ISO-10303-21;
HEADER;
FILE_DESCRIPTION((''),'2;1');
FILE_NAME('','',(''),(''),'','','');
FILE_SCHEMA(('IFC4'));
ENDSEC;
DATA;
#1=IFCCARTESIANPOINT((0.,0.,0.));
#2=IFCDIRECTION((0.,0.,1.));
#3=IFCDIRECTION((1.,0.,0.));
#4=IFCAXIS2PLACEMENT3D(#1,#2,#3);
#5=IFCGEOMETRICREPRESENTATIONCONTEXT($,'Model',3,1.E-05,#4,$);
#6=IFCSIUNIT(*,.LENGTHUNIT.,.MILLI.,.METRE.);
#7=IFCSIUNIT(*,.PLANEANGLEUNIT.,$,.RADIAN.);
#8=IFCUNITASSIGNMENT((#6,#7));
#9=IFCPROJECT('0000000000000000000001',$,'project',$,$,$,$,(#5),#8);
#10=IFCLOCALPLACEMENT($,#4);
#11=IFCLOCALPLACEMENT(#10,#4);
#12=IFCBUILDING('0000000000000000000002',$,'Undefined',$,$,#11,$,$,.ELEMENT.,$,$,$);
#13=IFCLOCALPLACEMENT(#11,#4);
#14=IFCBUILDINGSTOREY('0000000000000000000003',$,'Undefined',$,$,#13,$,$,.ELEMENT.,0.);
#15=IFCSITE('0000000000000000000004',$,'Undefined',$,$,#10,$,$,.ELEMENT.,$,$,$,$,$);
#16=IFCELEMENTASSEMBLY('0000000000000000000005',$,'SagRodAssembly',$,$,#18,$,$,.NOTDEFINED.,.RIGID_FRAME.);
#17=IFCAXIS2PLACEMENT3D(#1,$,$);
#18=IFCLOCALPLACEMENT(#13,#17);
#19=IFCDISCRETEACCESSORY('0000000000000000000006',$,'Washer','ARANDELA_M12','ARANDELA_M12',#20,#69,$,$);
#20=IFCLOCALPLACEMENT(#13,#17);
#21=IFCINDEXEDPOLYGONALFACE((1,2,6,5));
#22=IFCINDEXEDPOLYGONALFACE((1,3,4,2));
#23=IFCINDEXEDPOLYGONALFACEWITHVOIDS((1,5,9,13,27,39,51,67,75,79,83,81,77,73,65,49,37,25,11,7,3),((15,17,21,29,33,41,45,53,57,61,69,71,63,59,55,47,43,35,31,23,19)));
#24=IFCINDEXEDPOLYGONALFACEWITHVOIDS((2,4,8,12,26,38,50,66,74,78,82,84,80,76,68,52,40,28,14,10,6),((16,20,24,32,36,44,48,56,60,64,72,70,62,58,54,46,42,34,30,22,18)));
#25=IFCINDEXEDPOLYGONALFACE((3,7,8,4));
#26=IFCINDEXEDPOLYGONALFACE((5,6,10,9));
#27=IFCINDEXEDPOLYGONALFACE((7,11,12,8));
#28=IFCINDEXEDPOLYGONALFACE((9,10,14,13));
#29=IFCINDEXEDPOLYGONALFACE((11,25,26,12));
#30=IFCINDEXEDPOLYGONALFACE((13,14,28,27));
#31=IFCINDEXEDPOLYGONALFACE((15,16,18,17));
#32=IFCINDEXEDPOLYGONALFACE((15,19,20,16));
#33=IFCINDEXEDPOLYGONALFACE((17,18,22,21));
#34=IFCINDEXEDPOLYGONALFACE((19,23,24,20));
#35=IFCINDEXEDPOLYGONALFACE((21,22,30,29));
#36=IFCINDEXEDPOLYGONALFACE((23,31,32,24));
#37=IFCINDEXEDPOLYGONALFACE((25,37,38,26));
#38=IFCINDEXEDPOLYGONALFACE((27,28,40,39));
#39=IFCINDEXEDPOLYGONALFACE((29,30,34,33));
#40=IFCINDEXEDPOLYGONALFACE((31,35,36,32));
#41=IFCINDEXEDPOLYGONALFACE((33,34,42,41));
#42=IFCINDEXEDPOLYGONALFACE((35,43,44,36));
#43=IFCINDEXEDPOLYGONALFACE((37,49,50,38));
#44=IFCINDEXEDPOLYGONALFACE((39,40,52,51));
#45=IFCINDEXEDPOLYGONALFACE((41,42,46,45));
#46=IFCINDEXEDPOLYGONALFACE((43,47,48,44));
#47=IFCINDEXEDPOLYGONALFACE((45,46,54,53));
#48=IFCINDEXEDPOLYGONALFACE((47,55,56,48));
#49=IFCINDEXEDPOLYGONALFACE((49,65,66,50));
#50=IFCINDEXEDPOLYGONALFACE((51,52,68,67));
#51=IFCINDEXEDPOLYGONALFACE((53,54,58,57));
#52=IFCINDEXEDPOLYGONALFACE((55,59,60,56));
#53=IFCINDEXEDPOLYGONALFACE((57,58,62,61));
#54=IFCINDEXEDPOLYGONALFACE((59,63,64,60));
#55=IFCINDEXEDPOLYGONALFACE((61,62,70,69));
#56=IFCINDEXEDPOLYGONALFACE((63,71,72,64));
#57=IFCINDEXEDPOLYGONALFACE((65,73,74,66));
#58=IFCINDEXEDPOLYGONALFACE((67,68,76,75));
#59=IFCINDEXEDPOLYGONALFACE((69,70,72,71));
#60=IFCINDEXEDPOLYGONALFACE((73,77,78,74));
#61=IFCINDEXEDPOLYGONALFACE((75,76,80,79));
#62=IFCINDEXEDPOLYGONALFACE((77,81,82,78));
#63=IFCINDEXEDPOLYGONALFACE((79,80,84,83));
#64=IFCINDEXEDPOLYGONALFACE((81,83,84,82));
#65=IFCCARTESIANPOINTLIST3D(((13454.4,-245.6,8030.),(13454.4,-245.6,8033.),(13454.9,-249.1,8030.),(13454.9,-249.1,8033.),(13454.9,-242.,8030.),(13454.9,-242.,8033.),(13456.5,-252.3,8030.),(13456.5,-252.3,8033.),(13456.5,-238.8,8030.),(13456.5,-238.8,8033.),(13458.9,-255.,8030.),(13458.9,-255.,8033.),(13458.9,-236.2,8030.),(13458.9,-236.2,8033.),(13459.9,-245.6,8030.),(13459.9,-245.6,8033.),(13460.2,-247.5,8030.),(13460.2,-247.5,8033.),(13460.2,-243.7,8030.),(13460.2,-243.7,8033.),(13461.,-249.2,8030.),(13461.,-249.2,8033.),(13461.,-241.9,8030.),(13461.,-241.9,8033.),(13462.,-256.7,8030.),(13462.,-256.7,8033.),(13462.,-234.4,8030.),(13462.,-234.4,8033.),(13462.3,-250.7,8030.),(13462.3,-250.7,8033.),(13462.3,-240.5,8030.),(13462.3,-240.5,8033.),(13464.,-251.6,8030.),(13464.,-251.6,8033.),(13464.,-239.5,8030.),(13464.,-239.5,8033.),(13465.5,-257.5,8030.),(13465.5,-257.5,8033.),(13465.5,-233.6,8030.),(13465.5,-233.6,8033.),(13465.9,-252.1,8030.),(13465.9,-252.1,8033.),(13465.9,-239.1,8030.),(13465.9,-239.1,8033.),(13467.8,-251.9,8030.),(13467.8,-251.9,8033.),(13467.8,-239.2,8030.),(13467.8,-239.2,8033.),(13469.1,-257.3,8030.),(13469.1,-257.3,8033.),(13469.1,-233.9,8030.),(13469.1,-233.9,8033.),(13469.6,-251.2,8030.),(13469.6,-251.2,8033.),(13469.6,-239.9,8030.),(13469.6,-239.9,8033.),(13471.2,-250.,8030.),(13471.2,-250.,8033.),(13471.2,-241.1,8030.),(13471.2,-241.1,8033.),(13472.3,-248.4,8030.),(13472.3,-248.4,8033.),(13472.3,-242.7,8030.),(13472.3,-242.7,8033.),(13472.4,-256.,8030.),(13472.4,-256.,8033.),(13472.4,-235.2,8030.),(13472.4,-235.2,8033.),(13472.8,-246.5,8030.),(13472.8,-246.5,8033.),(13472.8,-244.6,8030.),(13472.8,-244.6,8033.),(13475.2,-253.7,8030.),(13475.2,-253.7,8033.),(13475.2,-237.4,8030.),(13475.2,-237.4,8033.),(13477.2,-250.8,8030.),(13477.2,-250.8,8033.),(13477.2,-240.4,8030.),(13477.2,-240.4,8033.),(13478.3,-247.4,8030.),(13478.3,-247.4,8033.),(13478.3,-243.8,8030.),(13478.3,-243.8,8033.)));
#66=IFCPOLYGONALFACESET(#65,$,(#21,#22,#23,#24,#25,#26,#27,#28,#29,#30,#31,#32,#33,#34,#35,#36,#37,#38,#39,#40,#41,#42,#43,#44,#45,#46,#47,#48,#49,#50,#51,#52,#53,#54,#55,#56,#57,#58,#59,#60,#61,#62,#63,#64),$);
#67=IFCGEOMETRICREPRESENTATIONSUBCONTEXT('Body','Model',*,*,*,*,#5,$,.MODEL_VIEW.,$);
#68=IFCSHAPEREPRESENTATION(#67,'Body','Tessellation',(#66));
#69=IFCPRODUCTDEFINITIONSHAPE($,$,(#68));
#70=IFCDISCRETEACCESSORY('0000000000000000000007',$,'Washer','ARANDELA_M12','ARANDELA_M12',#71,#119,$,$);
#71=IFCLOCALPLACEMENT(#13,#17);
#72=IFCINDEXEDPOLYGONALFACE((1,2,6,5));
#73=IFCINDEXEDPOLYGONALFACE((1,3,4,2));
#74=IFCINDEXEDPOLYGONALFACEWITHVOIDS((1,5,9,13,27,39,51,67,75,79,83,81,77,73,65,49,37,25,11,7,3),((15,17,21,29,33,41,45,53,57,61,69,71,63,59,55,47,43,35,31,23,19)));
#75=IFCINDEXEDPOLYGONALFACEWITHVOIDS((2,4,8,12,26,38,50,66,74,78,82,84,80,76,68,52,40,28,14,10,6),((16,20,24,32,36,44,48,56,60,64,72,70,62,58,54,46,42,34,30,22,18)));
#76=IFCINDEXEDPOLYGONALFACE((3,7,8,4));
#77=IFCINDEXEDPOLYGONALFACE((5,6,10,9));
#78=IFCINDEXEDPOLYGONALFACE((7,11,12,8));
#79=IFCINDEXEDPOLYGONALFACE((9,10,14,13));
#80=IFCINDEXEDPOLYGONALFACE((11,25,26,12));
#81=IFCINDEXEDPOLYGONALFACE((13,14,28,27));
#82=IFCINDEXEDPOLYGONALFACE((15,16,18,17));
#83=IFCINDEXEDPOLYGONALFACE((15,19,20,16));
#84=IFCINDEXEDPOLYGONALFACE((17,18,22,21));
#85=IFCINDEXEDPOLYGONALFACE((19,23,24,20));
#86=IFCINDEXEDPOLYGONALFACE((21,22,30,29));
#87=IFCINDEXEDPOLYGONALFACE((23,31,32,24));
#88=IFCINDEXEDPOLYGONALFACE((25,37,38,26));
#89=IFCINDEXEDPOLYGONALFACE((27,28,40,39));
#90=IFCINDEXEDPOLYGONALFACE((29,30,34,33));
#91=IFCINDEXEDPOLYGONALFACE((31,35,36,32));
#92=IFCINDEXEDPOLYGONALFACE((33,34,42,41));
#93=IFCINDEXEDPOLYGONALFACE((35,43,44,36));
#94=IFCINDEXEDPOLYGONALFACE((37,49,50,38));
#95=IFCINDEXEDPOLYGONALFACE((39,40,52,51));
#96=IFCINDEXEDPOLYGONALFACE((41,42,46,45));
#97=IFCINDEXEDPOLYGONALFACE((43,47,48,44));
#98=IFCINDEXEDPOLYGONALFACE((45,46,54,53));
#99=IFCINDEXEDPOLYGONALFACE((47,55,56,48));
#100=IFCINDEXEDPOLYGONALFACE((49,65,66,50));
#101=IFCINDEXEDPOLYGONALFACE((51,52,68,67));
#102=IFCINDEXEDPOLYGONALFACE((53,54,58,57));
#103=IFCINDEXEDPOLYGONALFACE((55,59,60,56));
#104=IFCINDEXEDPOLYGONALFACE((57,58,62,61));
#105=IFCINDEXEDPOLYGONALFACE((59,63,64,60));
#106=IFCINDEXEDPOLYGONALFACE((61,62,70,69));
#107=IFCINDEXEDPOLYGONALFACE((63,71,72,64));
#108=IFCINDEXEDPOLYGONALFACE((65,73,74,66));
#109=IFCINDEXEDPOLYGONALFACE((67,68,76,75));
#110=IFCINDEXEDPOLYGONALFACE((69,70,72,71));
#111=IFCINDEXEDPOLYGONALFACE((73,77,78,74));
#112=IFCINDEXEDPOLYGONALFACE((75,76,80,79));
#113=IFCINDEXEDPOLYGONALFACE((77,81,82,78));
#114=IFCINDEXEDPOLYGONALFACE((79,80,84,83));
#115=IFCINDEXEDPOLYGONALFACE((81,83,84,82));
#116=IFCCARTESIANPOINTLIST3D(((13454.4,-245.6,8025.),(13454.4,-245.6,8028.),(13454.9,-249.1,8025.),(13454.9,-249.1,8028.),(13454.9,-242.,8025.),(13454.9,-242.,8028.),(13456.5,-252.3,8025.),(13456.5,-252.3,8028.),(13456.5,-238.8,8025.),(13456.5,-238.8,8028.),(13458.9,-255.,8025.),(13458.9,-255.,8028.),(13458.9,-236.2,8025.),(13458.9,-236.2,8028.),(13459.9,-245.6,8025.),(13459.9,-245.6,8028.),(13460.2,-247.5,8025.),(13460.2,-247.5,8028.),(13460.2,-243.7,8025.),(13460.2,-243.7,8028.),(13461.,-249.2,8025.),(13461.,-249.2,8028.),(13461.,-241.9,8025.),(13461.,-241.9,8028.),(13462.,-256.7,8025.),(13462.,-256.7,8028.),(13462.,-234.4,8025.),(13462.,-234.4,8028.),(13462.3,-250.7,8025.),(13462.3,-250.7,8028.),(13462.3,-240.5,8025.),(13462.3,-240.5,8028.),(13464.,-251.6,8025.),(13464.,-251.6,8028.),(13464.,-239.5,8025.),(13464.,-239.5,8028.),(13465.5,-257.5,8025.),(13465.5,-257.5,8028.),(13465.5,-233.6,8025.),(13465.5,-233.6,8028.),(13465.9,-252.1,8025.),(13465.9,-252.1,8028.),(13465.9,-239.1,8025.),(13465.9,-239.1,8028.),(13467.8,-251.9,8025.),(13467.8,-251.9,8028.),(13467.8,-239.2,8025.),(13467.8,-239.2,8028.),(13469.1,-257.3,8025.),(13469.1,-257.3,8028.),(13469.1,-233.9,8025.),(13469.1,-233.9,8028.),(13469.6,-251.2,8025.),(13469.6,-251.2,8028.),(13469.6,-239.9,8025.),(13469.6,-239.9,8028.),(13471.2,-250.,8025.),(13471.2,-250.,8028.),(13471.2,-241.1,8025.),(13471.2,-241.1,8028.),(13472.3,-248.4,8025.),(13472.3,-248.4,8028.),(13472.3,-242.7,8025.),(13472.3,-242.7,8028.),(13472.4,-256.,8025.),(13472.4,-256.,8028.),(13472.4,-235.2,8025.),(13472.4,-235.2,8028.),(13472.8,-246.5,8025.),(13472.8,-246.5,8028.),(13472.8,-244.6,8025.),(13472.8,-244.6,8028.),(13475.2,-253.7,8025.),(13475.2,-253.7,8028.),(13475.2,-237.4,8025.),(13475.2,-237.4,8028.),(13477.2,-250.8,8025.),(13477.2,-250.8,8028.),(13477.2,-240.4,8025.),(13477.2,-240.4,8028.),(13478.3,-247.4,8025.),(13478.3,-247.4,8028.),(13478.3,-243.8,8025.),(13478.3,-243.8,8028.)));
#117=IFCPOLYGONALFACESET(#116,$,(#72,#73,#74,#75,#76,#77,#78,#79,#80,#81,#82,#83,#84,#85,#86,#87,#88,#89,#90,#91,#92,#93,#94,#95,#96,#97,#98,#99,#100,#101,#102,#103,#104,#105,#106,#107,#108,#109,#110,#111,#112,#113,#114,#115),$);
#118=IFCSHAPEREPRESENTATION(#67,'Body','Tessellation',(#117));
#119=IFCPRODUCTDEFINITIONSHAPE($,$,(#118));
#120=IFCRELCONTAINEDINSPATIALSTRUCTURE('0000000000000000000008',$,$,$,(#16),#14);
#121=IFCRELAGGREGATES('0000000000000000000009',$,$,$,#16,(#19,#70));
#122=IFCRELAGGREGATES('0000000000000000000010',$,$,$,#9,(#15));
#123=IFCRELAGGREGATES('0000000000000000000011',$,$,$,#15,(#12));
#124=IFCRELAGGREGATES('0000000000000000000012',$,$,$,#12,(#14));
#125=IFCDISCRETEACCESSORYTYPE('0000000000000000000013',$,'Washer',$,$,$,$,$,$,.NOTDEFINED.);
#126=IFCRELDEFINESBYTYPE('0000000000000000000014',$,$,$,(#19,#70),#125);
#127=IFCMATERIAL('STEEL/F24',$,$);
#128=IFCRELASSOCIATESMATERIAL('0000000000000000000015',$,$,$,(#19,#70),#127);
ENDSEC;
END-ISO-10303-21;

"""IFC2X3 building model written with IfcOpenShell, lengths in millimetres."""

from ifc_helpers import new_model, si_unit, frame, origin_with_axes, origin_2d_with_axis, place, context, subcontext, project, spatial, hollow_circle, extrude, material, type_object, element, aggregate, save


model = new_model("IFC2X3")

# Units and contexts
model_context = context("Model", 3, precision=1e-05, world=origin_with_axes())
body_context = subcontext(model_context, "Body", "Model", "MODEL_VIEW")
ifc_project = project(units=[si_unit("LENGTHUNIT", "METRE", prefix="MILLI"), si_unit("PLANEANGLEUNIT", "RADIAN")], contexts=[model_context])

# Site, building, storey
site_placement = place(None, origin_with_axes())
site = spatial("IfcSite", under=ifc_project, at=site_placement, Name="Undefined", CompositionType="ELEMENT")
building_placement = place(site_placement, origin_with_axes())
building = spatial("IfcBuilding", under=site, at=building_placement, Name="Undefined", CompositionType="ELEMENT")
storey_placement = place(building_placement, origin_with_axes())
storey = spatial("IfcBuildingStorey", under=building, at=storey_placement, Name="Undefined", CompositionType="ELEMENT", Elevation=0.0)

# Shared definitions
ifc_material_1 = material(Name="STEEL/F24")

# Element assembly
assembly_1_placement = place(storey_placement, origin_with_axes())
assembly_1 = element("IfcElementAssembly", 1, at=assembly_1_placement, inside=storey, Name="SagRodAssembly", AssemblyPlace="NOTDEFINED", PredefinedType="RIGID_FRAME")

# Discrete accessories
discrete_accessory_type_1 = type_object("IfcDiscreteAccessoryType", Name="Washer")
discrete_accessory_1_placement = place(assembly_1_placement, frame((13466.4, -245.6, 8030.0), z_axis=(0.0, 0.0, 1.0), x_axis=(0.0, 1.0, 0.0)))
discrete_accessory_1 = element("IfcDiscreteAccessory", 2, at=discrete_accessory_1_placement, type_object=discrete_accessory_type_1, material=ifc_material_1, Name="Washer", Description="ARANDELA_M12", ObjectType="ARANDELA_M12", context=body_context, shape_type="SweptSolid", body=[
    extrude(hollow_circle(Radius=12.0, WallThickness=5.5, at=origin_2d_with_axis()), frame((0.0, 0.0, 3.0), z_axis=(0.0, 0.0, -1.0), x_axis=(0.0, 1.0, 0.0)), (0.0, 0.0, 1.0), 3.0),
])
discrete_accessory_2_placement = place(assembly_1_placement, frame((13466.4, -245.6, 8025.0), z_axis=(0.0, 0.0, 1.0), x_axis=(0.0, 1.0, 0.0)))
discrete_accessory_2 = element("IfcDiscreteAccessory", 3, at=discrete_accessory_2_placement, type_object=discrete_accessory_type_1, material=ifc_material_1, Name="Washer", Description="ARANDELA_M12", ObjectType="ARANDELA_M12", context=body_context, shape_type="SweptSolid", body=[
    extrude(hollow_circle(Radius=12.0, WallThickness=5.5, at=origin_2d_with_axis()), frame((0.0, 0.0, 3.0), z_axis=(0.0, 0.0, -1.0), x_axis=(0.0, 1.0, 0.0)), (0.0, 0.0, 1.0), 3.0),
])
aggregate(assembly_1, [discrete_accessory_1, discrete_accessory_2])

save(model, "model.ifc")
